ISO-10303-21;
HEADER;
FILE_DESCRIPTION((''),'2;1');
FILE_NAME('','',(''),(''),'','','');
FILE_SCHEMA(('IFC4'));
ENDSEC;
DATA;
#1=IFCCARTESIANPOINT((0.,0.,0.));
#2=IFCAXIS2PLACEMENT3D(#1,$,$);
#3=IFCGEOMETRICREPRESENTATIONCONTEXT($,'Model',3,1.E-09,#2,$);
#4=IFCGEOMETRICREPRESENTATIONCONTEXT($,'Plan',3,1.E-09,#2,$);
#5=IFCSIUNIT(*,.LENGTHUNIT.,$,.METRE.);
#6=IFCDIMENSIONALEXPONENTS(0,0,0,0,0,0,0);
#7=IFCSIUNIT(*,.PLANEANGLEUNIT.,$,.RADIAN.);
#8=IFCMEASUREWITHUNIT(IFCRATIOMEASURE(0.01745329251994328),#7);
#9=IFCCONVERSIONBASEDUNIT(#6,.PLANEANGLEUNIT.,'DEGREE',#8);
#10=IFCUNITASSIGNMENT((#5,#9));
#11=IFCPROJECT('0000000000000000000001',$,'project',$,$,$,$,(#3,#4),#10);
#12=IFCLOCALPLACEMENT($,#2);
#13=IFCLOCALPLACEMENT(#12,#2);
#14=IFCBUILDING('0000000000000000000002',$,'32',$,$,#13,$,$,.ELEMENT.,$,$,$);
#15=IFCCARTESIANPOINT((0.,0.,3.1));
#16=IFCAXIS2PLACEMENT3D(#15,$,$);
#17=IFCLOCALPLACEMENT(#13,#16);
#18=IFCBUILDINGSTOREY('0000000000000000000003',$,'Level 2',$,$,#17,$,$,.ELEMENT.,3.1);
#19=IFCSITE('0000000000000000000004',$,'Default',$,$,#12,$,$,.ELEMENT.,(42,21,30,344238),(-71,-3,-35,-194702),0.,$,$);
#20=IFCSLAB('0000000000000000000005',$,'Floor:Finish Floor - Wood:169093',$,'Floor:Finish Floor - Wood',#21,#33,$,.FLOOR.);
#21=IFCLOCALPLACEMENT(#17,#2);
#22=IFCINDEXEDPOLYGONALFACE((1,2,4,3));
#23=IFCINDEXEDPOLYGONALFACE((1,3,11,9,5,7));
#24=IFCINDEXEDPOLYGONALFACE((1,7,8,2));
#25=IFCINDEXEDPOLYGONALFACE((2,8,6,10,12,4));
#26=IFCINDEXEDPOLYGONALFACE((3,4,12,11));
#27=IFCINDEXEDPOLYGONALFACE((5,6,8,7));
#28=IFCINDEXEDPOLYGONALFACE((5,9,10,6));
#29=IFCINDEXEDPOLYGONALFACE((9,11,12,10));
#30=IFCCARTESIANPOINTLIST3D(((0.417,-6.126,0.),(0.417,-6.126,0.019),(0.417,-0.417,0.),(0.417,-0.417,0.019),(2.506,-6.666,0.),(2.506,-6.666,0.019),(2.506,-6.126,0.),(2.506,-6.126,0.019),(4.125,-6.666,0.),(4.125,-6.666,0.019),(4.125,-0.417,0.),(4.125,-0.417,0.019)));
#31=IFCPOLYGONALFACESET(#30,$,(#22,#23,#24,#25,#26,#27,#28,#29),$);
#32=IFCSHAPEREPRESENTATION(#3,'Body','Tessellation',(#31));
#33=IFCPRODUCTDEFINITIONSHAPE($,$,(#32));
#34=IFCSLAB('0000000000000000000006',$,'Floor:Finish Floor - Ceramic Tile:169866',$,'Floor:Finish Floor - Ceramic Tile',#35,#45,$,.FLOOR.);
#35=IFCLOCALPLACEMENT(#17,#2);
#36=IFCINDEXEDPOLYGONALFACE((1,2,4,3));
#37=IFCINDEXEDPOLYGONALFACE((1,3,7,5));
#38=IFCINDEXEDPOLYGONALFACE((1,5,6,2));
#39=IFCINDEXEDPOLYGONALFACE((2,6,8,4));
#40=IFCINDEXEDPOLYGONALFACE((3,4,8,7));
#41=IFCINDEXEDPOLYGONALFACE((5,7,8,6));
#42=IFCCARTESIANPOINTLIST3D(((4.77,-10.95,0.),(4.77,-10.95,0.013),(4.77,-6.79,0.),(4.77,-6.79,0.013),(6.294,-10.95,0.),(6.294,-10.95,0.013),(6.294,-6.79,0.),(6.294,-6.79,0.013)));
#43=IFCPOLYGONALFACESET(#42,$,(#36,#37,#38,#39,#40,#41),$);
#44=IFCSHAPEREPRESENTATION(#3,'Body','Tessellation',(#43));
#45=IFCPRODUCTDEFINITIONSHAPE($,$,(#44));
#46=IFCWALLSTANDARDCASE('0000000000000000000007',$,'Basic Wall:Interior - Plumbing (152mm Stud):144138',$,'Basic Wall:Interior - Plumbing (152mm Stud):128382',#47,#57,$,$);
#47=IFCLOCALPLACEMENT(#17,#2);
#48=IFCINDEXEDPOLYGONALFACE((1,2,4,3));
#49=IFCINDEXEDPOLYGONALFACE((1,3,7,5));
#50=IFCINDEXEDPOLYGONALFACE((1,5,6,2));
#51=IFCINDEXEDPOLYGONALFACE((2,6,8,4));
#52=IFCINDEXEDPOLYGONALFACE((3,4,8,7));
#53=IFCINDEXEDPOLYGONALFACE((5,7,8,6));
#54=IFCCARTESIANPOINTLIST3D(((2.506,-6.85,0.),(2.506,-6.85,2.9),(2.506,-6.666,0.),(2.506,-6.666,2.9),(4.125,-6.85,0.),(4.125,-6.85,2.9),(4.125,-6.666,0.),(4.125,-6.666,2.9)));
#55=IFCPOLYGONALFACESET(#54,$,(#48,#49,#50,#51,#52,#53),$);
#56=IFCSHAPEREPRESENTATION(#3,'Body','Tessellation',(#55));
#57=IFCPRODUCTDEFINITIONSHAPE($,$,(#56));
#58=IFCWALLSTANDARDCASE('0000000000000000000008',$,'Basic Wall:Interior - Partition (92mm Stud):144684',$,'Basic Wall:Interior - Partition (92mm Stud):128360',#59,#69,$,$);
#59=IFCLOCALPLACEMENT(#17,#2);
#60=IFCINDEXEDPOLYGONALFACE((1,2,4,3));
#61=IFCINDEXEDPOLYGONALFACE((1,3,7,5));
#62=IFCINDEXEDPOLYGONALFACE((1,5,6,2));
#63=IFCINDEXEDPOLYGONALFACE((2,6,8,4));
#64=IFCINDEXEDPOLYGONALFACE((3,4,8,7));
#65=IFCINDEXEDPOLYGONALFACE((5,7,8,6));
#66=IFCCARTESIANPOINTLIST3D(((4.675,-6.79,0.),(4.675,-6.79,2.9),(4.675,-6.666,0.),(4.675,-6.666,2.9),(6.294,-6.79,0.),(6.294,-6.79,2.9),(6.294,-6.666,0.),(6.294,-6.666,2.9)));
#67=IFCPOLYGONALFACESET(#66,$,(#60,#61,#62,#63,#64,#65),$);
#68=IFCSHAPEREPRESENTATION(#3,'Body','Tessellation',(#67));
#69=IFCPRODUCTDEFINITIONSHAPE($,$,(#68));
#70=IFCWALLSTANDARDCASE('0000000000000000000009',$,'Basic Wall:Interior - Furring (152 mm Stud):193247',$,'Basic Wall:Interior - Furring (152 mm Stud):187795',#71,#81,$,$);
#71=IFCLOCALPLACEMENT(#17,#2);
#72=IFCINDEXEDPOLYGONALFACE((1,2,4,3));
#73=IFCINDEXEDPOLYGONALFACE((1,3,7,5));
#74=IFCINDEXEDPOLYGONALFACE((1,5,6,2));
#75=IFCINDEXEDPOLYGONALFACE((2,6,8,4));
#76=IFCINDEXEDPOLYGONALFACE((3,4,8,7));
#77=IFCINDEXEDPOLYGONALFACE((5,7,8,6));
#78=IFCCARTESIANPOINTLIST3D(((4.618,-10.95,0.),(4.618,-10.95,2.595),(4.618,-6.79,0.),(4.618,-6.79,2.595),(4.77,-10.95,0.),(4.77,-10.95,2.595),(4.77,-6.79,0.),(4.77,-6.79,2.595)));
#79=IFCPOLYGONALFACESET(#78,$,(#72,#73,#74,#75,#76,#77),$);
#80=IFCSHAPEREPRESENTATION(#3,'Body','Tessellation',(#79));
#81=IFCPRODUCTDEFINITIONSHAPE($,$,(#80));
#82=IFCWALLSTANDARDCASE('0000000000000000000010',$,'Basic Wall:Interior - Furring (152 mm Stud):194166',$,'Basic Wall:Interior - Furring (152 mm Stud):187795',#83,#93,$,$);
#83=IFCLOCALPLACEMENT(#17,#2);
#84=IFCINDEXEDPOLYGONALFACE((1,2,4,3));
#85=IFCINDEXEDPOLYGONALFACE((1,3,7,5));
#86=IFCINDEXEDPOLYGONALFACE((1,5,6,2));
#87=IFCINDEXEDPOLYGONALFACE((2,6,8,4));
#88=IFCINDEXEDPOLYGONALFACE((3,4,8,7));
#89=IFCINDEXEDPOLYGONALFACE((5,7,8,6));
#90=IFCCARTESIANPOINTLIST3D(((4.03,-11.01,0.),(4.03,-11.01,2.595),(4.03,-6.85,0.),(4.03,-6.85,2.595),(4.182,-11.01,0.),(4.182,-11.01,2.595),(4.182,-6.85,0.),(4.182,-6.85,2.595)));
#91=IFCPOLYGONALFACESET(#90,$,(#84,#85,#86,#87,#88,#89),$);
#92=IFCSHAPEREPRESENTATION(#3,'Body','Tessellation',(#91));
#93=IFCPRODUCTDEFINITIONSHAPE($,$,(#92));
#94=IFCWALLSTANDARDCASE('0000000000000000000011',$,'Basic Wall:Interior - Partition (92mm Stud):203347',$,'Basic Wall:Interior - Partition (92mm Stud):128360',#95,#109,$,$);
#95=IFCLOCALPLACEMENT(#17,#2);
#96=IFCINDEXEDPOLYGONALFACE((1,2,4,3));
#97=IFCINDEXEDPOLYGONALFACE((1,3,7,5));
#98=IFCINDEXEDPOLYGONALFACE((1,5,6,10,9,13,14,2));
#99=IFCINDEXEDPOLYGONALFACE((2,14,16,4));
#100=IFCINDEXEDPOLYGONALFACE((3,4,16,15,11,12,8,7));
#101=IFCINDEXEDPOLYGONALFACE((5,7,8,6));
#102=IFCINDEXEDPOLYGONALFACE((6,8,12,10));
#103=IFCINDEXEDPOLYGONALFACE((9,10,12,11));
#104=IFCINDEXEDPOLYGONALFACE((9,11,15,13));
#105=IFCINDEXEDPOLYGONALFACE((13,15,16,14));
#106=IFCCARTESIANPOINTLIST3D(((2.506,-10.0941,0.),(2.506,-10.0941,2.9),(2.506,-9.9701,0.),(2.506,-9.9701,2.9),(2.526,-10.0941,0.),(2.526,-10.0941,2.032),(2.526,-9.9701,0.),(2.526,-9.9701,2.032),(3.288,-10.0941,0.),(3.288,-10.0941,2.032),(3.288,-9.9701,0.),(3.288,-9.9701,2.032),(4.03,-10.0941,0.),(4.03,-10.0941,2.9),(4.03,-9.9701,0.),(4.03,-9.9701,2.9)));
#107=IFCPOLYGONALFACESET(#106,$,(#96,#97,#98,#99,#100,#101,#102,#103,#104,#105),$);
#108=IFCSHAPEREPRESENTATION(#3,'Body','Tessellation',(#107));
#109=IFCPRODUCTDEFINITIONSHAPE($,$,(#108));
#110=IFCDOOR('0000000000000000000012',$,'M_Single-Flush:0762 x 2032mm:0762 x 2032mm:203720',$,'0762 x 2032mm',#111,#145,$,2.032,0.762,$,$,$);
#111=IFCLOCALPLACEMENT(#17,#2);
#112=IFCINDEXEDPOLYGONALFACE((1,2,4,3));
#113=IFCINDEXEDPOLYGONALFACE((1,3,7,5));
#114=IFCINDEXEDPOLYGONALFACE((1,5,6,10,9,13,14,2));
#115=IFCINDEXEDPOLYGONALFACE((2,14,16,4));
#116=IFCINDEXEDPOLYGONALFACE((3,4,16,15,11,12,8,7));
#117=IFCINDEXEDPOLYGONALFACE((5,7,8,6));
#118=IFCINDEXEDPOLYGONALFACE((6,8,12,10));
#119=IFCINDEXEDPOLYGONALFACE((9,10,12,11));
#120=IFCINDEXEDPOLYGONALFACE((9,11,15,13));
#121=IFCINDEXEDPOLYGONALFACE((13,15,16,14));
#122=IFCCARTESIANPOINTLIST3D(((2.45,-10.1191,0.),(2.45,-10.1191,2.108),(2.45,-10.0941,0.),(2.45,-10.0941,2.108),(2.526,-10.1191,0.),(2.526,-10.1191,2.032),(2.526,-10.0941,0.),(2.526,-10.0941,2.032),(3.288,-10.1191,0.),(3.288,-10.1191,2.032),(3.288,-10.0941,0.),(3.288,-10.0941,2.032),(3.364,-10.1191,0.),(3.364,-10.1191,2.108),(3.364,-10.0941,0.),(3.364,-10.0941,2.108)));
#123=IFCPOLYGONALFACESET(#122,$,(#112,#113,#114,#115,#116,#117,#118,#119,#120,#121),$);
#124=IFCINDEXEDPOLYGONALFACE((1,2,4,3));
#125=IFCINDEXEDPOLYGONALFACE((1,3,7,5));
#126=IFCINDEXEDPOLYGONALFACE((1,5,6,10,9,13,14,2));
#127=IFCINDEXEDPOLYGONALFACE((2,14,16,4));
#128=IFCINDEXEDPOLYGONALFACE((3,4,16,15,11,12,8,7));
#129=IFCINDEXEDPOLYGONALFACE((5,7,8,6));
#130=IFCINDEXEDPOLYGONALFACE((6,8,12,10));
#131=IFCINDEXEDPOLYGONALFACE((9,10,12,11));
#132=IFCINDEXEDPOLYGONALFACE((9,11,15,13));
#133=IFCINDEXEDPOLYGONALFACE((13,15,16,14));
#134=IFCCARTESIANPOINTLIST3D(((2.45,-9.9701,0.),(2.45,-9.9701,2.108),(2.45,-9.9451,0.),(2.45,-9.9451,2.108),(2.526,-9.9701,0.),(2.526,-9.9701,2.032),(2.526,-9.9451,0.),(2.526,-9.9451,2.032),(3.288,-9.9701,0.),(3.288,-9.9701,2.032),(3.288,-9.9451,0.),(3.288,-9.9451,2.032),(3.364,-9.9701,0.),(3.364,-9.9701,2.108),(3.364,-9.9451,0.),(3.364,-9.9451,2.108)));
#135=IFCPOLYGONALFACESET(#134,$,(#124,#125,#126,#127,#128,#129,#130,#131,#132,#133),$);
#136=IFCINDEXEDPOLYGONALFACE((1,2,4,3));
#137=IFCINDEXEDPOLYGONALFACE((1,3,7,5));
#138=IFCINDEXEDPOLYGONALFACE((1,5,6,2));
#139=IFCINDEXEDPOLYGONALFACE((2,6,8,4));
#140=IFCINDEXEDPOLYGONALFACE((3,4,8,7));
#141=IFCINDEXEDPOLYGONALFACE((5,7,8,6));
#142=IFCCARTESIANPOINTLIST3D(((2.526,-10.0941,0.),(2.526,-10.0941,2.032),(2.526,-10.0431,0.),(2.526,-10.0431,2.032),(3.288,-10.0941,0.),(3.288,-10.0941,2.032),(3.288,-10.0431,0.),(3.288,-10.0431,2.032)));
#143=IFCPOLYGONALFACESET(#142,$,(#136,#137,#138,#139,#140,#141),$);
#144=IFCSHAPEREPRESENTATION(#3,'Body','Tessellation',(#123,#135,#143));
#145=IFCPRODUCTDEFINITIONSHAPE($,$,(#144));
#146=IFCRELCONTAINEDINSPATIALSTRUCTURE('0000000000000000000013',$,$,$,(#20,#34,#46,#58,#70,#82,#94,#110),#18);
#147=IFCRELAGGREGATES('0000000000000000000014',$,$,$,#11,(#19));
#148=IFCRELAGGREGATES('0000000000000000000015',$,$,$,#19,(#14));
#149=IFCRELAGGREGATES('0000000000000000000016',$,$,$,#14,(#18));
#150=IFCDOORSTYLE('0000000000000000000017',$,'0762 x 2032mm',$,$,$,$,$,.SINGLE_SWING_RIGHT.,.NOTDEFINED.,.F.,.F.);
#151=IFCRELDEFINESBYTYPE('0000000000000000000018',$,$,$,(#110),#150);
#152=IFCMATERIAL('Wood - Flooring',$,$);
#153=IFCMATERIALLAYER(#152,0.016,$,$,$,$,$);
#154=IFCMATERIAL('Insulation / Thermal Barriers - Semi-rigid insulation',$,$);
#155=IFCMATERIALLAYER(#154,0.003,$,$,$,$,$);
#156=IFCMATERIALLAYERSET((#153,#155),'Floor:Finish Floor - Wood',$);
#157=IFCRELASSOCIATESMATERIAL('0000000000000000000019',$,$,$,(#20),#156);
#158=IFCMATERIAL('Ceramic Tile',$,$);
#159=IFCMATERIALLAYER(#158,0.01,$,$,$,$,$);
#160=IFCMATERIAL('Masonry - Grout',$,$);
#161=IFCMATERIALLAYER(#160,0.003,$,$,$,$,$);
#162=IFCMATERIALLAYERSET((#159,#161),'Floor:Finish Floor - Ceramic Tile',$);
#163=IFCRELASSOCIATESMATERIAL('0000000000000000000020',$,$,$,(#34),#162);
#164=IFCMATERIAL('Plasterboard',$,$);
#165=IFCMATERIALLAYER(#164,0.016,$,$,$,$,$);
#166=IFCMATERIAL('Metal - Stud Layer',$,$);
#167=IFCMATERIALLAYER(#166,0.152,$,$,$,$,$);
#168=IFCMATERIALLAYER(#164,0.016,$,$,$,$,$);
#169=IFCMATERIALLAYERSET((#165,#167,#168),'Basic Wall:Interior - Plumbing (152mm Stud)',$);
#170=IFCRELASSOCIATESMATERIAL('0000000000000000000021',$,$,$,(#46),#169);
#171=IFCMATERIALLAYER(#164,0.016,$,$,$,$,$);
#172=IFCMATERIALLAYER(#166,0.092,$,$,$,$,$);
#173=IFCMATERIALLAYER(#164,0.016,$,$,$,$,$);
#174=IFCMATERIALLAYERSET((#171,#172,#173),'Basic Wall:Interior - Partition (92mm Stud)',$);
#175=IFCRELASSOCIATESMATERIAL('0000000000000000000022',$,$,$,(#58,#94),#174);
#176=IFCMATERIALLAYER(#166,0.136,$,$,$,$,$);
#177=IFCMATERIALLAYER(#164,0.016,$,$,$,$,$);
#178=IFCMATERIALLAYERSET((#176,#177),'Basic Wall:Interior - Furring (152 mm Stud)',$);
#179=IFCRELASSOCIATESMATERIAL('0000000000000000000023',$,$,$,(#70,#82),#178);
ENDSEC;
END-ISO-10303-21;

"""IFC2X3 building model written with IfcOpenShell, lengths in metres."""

from ifc_helpers import new_model, entity, si_unit, converted_unit, frame, frame_2d, origin, origin_2d_with_axis, place, context, project, spatial, polyline, rectangle, outline, extrude, source, transform, mapped, material, layer, layer_set, layer_usage, type_object, type_shapes, element, fill, save


model = new_model("IFC2X3")

# Units and contexts
model_context = context("Model", 3, precision=1e-09, world=origin())
plan_context = context("Plan", 3, precision=1e-09, world=origin())
ifc_project = project(units=[si_unit("LENGTHUNIT", "METRE"), converted_unit("PLANEANGLEUNIT", "DEGREE", entity("IfcRatioMeasure", 0.01745329251994328), si_unit("PLANEANGLEUNIT", "RADIAN"), dimensions=[0, 0, 0, 0, 0, 0, 0])], contexts=[model_context, plan_context])

# Site, building, storey
site_placement = place(None, origin())
site = spatial("IfcSite", under=ifc_project, at=site_placement, Name="Default", CompositionType="ELEMENT", RefLatitude=(42, 21, 30, 344238), RefLongitude=(-71, -3, -35, -194702), RefElevation=0.0)
building_placement = place(site_placement, origin())
building = spatial("IfcBuilding", under=site, at=building_placement, Name="32", CompositionType="ELEMENT")
storey_placement = place(building_placement, frame((0.0, 0.0, 3.1)))
storey = spatial("IfcBuildingStorey", under=building, at=storey_placement, Name="Level 2", CompositionType="ELEMENT", Elevation=3.1)

# Slabs
ifc_material_1 = material(Name="Wood - Flooring")
ifc_layer_1 = layer(ifc_material_1, 0.016)
ifc_material_2 = material(Name="Insulation / Thermal Barriers - Semi-rigid insulation")
ifc_layer_2 = layer(ifc_material_2, 0.003)
ifc_layer_set_1 = layer_set([ifc_layer_1, ifc_layer_2], Name="Floor:Finish Floor - Wood")
ifc_layer_usage_1 = layer_usage(ifc_layer_set_1, "AXIS3", "POSITIVE", 0.0)
slab_1_placement = place(storey_placement, frame((0.417, -6.666, 0.0)))
element("IfcSlab", 1, at=slab_1_placement, inside=storey, material=ifc_layer_usage_1, Name="Floor:Finish Floor - Wood:169093", ObjectType="Floor:Finish Floor - Wood", PredefinedType="FLOOR", context=model_context, shape_type="SweptSolid", body=[
    extrude(outline(polyline([(1.854, 3.1245), (-1.854, 3.1245), (-1.854, -3.1245), (-0.235, -3.1245), (-0.235, -2.5845), (1.854, -2.5845), (1.854, 3.1245)])), frame((1.854, 3.1245, 0.019), z_axis=(0.0, 0.0, -1.0), x_axis=(-1.0, 0.0, 0.0)), (0.0, 0.0, 1.0), 0.019),
])
ifc_material_3 = material(Name="Ceramic Tile")
ifc_layer_3 = layer(ifc_material_3, 0.01)
ifc_material_4 = material(Name="Masonry - Grout")
ifc_layer_4 = layer(ifc_material_4, 0.003)
ifc_layer_set_2 = layer_set([ifc_layer_3, ifc_layer_4], Name="Floor:Finish Floor - Ceramic Tile")
ifc_layer_usage_2 = layer_usage(ifc_layer_set_2, "AXIS3", "POSITIVE", 0.0)
slab_2_placement = place(storey_placement, frame((4.77, -10.95, 0.0)))
element("IfcSlab", 2, at=slab_2_placement, inside=storey, material=ifc_layer_usage_2, Name="Floor:Finish Floor - Ceramic Tile:169866", ObjectType="Floor:Finish Floor - Ceramic Tile", PredefinedType="FLOOR", context=model_context, shape_type="SweptSolid", body=[
    extrude(rectangle(XDim=4.16, YDim=1.524, at=frame_2d((0.0, 0.0), x_axis=(0.0, -1.0))), frame((0.762, 2.08, 0.013), z_axis=(0.0, 0.0, -1.0), x_axis=(-1.0, 0.0, 0.0)), (0.0, 0.0, 1.0), 0.013),
])

# Walls
ifc_material_5 = material(Name="Plasterboard")
ifc_layer_5 = layer(ifc_material_5, 0.016)
ifc_material_6 = material(Name="Metal - Stud Layer")
ifc_layer_6 = layer(ifc_material_6, 0.152)
ifc_layer_7 = layer(ifc_material_5, 0.016)
ifc_layer_set_3 = layer_set([ifc_layer_5, ifc_layer_6, ifc_layer_7], Name="Basic Wall:Interior - Plumbing (152mm Stud)")
ifc_layer_usage_3 = layer_usage(ifc_layer_set_3, "AXIS2", "NEGATIVE", 0.092)
wall_1_placement = place(storey_placement, frame((2.506, -6.758, 0.0)))
element("IfcWallStandardCase", 3, at=wall_1_placement, inside=storey, material=ifc_layer_usage_3, Name="Basic Wall:Interior - Plumbing (152mm Stud):144138", ObjectType="Basic Wall:Interior - Plumbing (152mm Stud):128382", context=model_context, shape_type="SweptSolid", body=[
    extrude(rectangle(XDim=1.619, YDim=0.184, at=frame_2d((0.8095, 0.0), x_axis=(-1.0, 0.0))), origin(), (0.0, 0.0, 1.0), 2.9),
])
ifc_layer_8 = layer(ifc_material_5, 0.016)
ifc_layer_9 = layer(ifc_material_6, 0.092)
ifc_layer_10 = layer(ifc_material_5, 0.016)
ifc_layer_set_4 = layer_set([ifc_layer_8, ifc_layer_9, ifc_layer_10], Name="Basic Wall:Interior - Partition (92mm Stud)")
ifc_layer_usage_4 = layer_usage(ifc_layer_set_4, "AXIS2", "NEGATIVE", 0.062)
wall_2_placement = place(storey_placement, frame((4.675, -6.728, 0.0)))
element("IfcWallStandardCase", 4, at=wall_2_placement, inside=storey, material=ifc_layer_usage_4, Name="Basic Wall:Interior - Partition (92mm Stud):144684", ObjectType="Basic Wall:Interior - Partition (92mm Stud):128360", context=model_context, shape_type="SweptSolid", body=[
    extrude(rectangle(XDim=1.619, YDim=0.124, at=frame_2d((0.8095, 0.0), x_axis=(-1.0, 0.0))), origin(), (0.0, 0.0, 1.0), 2.9),
])
ifc_layer_11 = layer(ifc_material_6, 0.136)
ifc_layer_12 = layer(ifc_material_5, 0.016)
ifc_layer_set_5 = layer_set([ifc_layer_11, ifc_layer_12], Name="Basic Wall:Interior - Furring (152 mm Stud)")
ifc_layer_usage_5 = layer_usage(ifc_layer_set_5, "AXIS2", "POSITIVE", -0.076)
wall_3_placement = place(storey_placement, frame((4.694, -6.79, 0.0), z_axis=(0.0, 0.0, 1.0), x_axis=(0.0, -1.0, 0.0)))
element("IfcWallStandardCase", 5, at=wall_3_placement, inside=storey, material=ifc_layer_usage_5, Name="Basic Wall:Interior - Furring (152 mm Stud):193247", ObjectType="Basic Wall:Interior - Furring (152 mm Stud):187795", context=model_context, shape_type="SweptSolid", body=[
    extrude(rectangle(XDim=4.16, YDim=0.152, at=frame_2d((2.08, 0.0), x_axis=(-1.0, 0.0))), origin(), (0.0, 0.0, 1.0), 2.595),
])
ifc_layer_usage_6 = layer_usage(ifc_layer_set_5, "AXIS2", "POSITIVE", -0.076)
wall_4_placement = place(storey_placement, frame((4.106, -11.01, 0.0), z_axis=(0.0, 0.0, 1.0), x_axis=(0.0, 1.0, 0.0)))
element("IfcWallStandardCase", 6, at=wall_4_placement, inside=storey, material=ifc_layer_usage_6, Name="Basic Wall:Interior - Furring (152 mm Stud):194166", ObjectType="Basic Wall:Interior - Furring (152 mm Stud):187795", context=model_context, shape_type="SweptSolid", body=[
    extrude(rectangle(XDim=4.16, YDim=0.152, at=frame_2d((2.08, 0.0), x_axis=(-1.0, 0.0))), origin(), (0.0, 0.0, 1.0), 2.595),
])

# Wall, opening, door
ifc_layer_usage_7 = layer_usage(ifc_layer_set_4, "AXIS2", "NEGATIVE", 0.062)
wall_5_placement = place(storey_placement, frame((4.03, -10.0321, 0.0), z_axis=(0.0, 0.0, 1.0), x_axis=(-1.0, 0.0, 0.0)))
wall_5 = element("IfcWallStandardCase", 7, at=wall_5_placement, inside=storey, material=ifc_layer_usage_7, Name="Basic Wall:Interior - Partition (92mm Stud):203347", ObjectType="Basic Wall:Interior - Partition (92mm Stud):128360", context=model_context, shape_type="SweptSolid", body=[
    extrude(rectangle(XDim=1.524, YDim=0.124, at=frame_2d((0.762, 0.0), x_axis=(-1.0, 0.0))), origin(), (0.0, 0.0, 1.0), 2.9),
])
opening_1_placement = place(wall_5_placement, frame((0.742, -0.062, 0.0)))
opening_1 = element("IfcOpeningElement", 8, at=opening_1_placement, cuts=wall_5, ObjectType="Opening", context=model_context, shape_type="SweptSolid", body=[
    extrude(rectangle(XDim=0.762, YDim=2.032, at=frame_2d((1.016, 0.381), x_axis=(0.0, 1.0))), frame((0.0, 0.0, 0.0), z_axis=(0.0, 1.0, 0.0), x_axis=(0.0, 0.0, 1.0)), (0.0, 0.0, 1.0), 0.124),
])
door_style = type_object("IfcDoorStyle", Name="0762 x 2032mm", ConstructionType="NOTDEFINED", OperationType="SINGLE_SWING_RIGHT", ParameterTakesPrecedence=False, Sizeable=False)
shared_shape = source(origin(), model_context, "Body", "SweptSolid", [
    extrude(outline(polyline([(-0.457, -1.073), (0.457, -1.073), (0.457, 1.035), (0.381, 1.035), (0.381, -0.997), (-0.381, -0.997), (-0.381, 1.035), (-0.457, 1.035), (-0.457, -1.073)])), frame((0.381, 0.124, 1.035), z_axis=(0.0, 1.0, 0.0), x_axis=(1.0, 0.0, 0.0)), (0.0, 0.0, 1.0), 0.025),
    extrude(outline(polyline([(-1.073, -0.457), (1.035, -0.457), (1.035, -0.381), (-0.997, -0.381), (-0.997, 0.381), (1.035, 0.381), (1.035, 0.457), (-1.073, 0.457), (-1.073, -0.457)])), frame((0.381, -0.025, 1.035), z_axis=(0.0, 1.0, 0.0), x_axis=(0.0, 0.0, -1.0)), (0.0, 0.0, 1.0), 0.025),
    extrude(rectangle(XDim=0.051, YDim=0.762, at=origin_2d_with_axis()), frame((0.381, 0.0985, 0.0), z_axis=(0.0, 0.0, 1.0), x_axis=(0.0, 1.0, 0.0)), (0.0, 0.0, 1.0), 2.032),
])
type_shapes(door_style, [shared_shape])
door_1_placement = place(opening_1_placement, origin())
door_1 = element("IfcDoor", 9, at=door_1_placement, inside=storey, type_object=door_style, Name="M_Single-Flush:0762 x 2032mm:0762 x 2032mm:203720", ObjectType="0762 x 2032mm", OverallHeight=2.032, OverallWidth=0.762, context=model_context, shape_type="MappedRepresentation", body=[
    mapped(shared_shape, transform((0.0, 0.0, 0.0), scale=1.0)),
])
fill(opening_1, door_1)

save(model, "model.ifc")
